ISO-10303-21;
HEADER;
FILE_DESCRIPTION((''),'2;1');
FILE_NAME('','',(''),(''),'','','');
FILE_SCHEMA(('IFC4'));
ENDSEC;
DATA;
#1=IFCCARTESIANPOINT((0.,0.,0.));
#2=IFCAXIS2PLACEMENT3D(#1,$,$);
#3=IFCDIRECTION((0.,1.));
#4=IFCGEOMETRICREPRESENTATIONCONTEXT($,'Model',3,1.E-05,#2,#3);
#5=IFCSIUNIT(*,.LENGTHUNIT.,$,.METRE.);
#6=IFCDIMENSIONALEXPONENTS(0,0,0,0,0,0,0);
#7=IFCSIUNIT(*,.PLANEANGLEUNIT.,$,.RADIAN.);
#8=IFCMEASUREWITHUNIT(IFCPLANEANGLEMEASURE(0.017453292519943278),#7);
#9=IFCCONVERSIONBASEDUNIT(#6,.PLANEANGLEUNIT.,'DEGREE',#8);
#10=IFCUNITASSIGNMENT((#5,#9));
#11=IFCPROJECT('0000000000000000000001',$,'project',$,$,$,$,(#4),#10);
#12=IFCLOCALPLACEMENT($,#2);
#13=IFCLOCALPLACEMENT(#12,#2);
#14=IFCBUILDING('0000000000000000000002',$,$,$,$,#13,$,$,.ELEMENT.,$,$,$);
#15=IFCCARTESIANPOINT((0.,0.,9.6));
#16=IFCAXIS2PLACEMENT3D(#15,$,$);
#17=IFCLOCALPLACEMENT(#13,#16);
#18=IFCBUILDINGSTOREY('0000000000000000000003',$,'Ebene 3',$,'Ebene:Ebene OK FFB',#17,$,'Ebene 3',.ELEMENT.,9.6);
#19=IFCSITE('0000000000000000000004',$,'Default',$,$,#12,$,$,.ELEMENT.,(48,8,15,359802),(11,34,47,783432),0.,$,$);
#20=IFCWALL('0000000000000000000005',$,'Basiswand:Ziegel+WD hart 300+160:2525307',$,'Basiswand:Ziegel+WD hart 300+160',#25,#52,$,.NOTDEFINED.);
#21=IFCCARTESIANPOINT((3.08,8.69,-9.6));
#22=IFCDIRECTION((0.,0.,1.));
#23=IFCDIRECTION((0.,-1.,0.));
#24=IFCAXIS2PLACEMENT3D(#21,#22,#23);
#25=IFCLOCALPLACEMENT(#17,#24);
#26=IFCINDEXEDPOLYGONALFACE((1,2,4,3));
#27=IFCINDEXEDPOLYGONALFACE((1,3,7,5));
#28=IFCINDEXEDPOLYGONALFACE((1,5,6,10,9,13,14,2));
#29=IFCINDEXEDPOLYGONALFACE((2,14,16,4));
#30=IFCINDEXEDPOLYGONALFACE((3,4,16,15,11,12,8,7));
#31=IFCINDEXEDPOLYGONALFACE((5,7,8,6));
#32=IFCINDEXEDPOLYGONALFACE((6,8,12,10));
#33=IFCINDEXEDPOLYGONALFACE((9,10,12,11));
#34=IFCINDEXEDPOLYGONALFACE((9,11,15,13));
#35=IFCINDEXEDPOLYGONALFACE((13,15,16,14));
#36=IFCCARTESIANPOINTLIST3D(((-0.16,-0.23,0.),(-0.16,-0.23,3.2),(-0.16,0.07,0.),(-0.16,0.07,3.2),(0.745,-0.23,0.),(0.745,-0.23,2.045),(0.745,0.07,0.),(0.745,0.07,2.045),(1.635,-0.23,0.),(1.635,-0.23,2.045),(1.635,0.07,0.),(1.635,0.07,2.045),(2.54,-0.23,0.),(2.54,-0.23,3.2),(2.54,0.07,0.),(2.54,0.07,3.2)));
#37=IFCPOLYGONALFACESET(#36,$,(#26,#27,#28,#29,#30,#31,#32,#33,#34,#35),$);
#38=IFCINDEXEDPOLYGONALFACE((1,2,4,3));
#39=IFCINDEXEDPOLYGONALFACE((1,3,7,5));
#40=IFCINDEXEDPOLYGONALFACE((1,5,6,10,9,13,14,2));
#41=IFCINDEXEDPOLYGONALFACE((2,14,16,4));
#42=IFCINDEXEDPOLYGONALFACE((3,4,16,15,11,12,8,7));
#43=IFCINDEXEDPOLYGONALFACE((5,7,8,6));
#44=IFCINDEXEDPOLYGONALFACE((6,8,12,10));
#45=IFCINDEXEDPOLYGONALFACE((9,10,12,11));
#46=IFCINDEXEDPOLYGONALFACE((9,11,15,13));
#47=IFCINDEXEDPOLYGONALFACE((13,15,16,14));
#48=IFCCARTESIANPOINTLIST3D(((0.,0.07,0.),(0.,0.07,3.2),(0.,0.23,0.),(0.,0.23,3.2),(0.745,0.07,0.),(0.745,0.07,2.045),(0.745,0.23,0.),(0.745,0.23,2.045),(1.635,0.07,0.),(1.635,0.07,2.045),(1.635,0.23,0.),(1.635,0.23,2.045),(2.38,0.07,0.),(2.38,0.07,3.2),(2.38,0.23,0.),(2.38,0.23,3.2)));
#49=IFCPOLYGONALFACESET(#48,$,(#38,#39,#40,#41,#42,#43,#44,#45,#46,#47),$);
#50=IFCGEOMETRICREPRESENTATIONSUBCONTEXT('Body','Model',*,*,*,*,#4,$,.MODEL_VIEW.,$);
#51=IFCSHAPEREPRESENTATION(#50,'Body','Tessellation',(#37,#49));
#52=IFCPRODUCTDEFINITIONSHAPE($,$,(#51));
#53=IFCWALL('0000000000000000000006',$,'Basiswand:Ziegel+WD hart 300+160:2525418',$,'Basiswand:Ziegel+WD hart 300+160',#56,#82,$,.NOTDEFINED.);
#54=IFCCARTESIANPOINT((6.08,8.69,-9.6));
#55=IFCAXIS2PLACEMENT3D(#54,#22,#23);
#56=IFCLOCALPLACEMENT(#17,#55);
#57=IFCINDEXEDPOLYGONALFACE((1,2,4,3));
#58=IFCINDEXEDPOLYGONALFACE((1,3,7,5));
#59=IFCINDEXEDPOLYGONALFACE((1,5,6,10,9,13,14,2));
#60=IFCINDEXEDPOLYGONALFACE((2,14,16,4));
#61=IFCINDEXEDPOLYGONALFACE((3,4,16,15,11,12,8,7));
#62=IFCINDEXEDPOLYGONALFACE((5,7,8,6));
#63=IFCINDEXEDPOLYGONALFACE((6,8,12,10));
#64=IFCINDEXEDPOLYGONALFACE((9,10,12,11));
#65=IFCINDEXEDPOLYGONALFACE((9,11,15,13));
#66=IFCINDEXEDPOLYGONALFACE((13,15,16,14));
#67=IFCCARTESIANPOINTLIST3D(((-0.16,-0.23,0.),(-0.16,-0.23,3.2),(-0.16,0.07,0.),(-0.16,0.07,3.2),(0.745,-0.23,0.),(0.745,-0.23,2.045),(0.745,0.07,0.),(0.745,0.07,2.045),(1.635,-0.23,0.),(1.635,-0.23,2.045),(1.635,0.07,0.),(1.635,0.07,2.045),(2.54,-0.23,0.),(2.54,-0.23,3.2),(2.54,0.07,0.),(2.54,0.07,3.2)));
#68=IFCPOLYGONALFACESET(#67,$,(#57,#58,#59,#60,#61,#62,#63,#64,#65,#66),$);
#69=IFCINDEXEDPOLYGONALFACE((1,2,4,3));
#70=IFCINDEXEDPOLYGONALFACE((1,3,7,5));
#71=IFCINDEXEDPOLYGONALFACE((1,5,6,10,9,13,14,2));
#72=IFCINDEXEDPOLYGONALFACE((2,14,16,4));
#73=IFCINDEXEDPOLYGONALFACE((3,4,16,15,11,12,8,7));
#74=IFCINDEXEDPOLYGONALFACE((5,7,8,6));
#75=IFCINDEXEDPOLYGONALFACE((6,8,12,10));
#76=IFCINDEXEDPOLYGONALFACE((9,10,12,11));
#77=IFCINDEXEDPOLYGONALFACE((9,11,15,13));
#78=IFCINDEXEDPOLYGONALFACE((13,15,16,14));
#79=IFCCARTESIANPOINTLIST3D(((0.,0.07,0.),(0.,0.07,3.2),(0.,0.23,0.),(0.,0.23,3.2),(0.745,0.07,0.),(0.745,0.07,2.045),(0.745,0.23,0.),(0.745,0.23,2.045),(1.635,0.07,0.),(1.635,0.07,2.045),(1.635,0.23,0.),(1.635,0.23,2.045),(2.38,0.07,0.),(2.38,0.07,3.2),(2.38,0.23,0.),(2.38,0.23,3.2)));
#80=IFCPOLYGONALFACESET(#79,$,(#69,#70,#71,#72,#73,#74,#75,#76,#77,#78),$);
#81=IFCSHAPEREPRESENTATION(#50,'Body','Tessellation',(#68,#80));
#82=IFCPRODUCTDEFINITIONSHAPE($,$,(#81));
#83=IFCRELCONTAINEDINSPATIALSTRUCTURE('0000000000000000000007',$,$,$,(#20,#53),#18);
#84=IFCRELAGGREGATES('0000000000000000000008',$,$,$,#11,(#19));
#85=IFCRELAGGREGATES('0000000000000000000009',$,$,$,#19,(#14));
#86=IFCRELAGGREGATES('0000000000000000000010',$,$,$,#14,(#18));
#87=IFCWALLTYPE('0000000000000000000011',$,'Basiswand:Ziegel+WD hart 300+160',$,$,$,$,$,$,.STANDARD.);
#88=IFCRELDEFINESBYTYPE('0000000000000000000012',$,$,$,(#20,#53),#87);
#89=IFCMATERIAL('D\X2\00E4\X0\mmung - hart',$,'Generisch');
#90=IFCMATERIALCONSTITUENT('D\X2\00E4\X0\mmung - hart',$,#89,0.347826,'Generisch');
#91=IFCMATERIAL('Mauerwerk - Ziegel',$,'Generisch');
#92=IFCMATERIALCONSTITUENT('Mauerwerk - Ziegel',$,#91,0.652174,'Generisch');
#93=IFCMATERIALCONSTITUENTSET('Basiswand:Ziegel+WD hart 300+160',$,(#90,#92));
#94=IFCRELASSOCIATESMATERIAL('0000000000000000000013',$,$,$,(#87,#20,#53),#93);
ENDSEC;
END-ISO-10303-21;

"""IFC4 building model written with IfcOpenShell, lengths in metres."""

from ifc_helpers import new_model, entity, si_unit, converted_unit, direction, frame, origin, place, context, subcontext, project, spatial, indexed_curve, outline, extrude, material, constituent, constituent_set, type_object, element, save


model = new_model("IFC4")

# Units and contexts
model_context = context("Model", 3, precision=1e-05, world=origin(), true_north=direction((0.0, 1.0)))
body_context = subcontext(model_context, "Body", "Model", "MODEL_VIEW")
ifc_project = project(units=[si_unit("LENGTHUNIT", "METRE"), converted_unit("PLANEANGLEUNIT", "DEGREE", entity("IfcPlaneAngleMeasure", 0.017453292519943278), si_unit("PLANEANGLEUNIT", "RADIAN"), dimensions=[0, 0, 0, 0, 0, 0, 0])], contexts=[model_context])

# Site, building, storey
site_placement = place(None, origin())
site = spatial("IfcSite", under=ifc_project, at=site_placement, Name="Default", CompositionType="ELEMENT", RefLatitude=(48, 8, 15, 359802), RefLongitude=(11, 34, 47, 783432), RefElevation=0.0)
building_placement = place(site_placement, origin())
building = spatial("IfcBuilding", under=site, at=building_placement, CompositionType="ELEMENT")
storey_placement = place(building_placement, frame((0.0, 0.0, 9.6)))
storey = spatial("IfcBuildingStorey", under=building, at=storey_placement, Name="Ebene 3", ObjectType="Ebene:Ebene OK FFB", LongName="Ebene 3", CompositionType="ELEMENT", Elevation=9.6)

# Shared definitions
ifc_material_1 = material(Name="Dämmung - hart", Category="Generisch")
ifc_constituent_1 = constituent(ifc_material_1, Name="Dämmung - hart", Category="Generisch", fraction=0.347826)
ifc_material_2 = material(Name="Mauerwerk - Ziegel", Category="Generisch")
ifc_constituent_2 = constituent(ifc_material_2, Name="Mauerwerk - Ziegel", Category="Generisch", fraction=0.652174)
ifc_constituent_set = constituent_set(constituents=[ifc_constituent_1, ifc_constituent_2], Name="Basiswand:Ziegel+WD hart 300+160")
wall_type = type_object("IfcWallType", Name="Basiswand:Ziegel+WD hart 300+160", PredefinedType="STANDARD", material=ifc_constituent_set)

# Walls, openings
wall_1_placement = place(storey_placement, frame((3.08, 8.69, -9.6), z_axis=(0.0, 0.0, 1.0), x_axis=(0.0, -1.0, 0.0)))
wall_1 = element("IfcWall", 1, at=wall_1_placement, inside=storey, type_object=wall_type, material=ifc_constituent_set, Name="Basiswand:Ziegel+WD hart 300+160:2525307", ObjectType="Basiswand:Ziegel+WD hart 300+160", PredefinedType="NOTDEFINED", context=body_context, shape_type="SweptSolid", body=[
    extrude(outline(indexed_curve([(-1.8888, -1.35), (1.3112, -1.35), (1.3112, -0.445), (-0.7337, -0.445), (-0.7337, 0.445), (1.3112, 0.445), (1.3112, 1.35), (-1.8888, 1.35), (-1.8888, -1.35)], self_intersect=False)), frame((1.19, -0.23, 1.3112), z_axis=(0.0, 1.0, 0.0), x_axis=(0.0, 0.0, -1.0)), (0.0, 0.0, 1.0), 0.3),
    extrude(outline(indexed_curve([(-1.3112, -1.19), (1.8888, -1.19), (1.8888, 1.19), (-1.3112, 1.19), (-1.3112, 0.445), (0.7337, 0.445), (0.7337, -0.445), (-1.3112, -0.445), (-1.3112, -1.19)], self_intersect=False)), frame((1.19, 0.07, 1.3112), z_axis=(0.0, 1.0, 0.0), x_axis=(0.0, 0.0, 1.0)), (0.0, 0.0, 1.0), 0.16),
])
opening_1_placement = place(wall_1_placement, frame((0.745, -0.23, -0.18)))
element("IfcOpeningElement", 2, at=opening_1_placement, cuts=wall_1, PredefinedType="OPENING", context=body_context, shape_type="SweptSolid", body=[
    extrude(outline(indexed_curve([(2.225, 0.89), (0.0, 0.89), (0.0, 0.0), (2.225, 0.0), (2.225, 0.89)], self_intersect=False)), frame((0.0, 0.0, 0.0), z_axis=(0.0, 1.0, 0.0), x_axis=(0.0, 0.0, 1.0)), (0.0, 0.0, 1.0), 0.46),
])
wall_2_placement = place(storey_placement, frame((6.08, 8.69, -9.6), z_axis=(0.0, 0.0, 1.0), x_axis=(0.0, -1.0, 0.0)))
wall_2 = element("IfcWall", 3, at=wall_2_placement, inside=storey, type_object=wall_type, material=ifc_constituent_set, Name="Basiswand:Ziegel+WD hart 300+160:2525418", ObjectType="Basiswand:Ziegel+WD hart 300+160", PredefinedType="NOTDEFINED", context=body_context, shape_type="SweptSolid", body=[
    extrude(outline(indexed_curve([(-1.8888, -1.35), (1.3112, -1.35), (1.3112, -0.445), (-0.7337, -0.445), (-0.7337, 0.445), (1.3112, 0.445), (1.3112, 1.35), (-1.8888, 1.35), (-1.8888, -1.35)], self_intersect=False)), frame((1.19, -0.23, 1.3112), z_axis=(0.0, 1.0, 0.0), x_axis=(0.0, 0.0, -1.0)), (0.0, 0.0, 1.0), 0.3),
    extrude(outline(indexed_curve([(-1.3112, -1.19), (1.8888, -1.19), (1.8888, 1.19), (-1.3112, 1.19), (-1.3112, 0.445), (0.7337, 0.445), (0.7337, -0.445), (-1.3112, -0.445), (-1.3112, -1.19)], self_intersect=False)), frame((1.19, 0.07, 1.3112), z_axis=(0.0, 1.0, 0.0), x_axis=(0.0, 0.0, 1.0)), (0.0, 0.0, 1.0), 0.16),
])
opening_2_placement = place(wall_2_placement, frame((0.745, -0.23, -0.18)))
element("IfcOpeningElement", 4, at=opening_2_placement, cuts=wall_2, PredefinedType="OPENING", context=body_context, shape_type="SweptSolid", body=[
    extrude(outline(indexed_curve([(2.225, 0.89), (0.0, 0.89), (0.0, 0.0), (2.225, 0.0), (2.225, 0.89)], self_intersect=False)), frame((0.0, 0.0, 0.0), z_axis=(0.0, 1.0, 0.0), x_axis=(0.0, 0.0, 1.0)), (0.0, 0.0, 1.0), 0.46),
])

save(model, "model.ifc")
